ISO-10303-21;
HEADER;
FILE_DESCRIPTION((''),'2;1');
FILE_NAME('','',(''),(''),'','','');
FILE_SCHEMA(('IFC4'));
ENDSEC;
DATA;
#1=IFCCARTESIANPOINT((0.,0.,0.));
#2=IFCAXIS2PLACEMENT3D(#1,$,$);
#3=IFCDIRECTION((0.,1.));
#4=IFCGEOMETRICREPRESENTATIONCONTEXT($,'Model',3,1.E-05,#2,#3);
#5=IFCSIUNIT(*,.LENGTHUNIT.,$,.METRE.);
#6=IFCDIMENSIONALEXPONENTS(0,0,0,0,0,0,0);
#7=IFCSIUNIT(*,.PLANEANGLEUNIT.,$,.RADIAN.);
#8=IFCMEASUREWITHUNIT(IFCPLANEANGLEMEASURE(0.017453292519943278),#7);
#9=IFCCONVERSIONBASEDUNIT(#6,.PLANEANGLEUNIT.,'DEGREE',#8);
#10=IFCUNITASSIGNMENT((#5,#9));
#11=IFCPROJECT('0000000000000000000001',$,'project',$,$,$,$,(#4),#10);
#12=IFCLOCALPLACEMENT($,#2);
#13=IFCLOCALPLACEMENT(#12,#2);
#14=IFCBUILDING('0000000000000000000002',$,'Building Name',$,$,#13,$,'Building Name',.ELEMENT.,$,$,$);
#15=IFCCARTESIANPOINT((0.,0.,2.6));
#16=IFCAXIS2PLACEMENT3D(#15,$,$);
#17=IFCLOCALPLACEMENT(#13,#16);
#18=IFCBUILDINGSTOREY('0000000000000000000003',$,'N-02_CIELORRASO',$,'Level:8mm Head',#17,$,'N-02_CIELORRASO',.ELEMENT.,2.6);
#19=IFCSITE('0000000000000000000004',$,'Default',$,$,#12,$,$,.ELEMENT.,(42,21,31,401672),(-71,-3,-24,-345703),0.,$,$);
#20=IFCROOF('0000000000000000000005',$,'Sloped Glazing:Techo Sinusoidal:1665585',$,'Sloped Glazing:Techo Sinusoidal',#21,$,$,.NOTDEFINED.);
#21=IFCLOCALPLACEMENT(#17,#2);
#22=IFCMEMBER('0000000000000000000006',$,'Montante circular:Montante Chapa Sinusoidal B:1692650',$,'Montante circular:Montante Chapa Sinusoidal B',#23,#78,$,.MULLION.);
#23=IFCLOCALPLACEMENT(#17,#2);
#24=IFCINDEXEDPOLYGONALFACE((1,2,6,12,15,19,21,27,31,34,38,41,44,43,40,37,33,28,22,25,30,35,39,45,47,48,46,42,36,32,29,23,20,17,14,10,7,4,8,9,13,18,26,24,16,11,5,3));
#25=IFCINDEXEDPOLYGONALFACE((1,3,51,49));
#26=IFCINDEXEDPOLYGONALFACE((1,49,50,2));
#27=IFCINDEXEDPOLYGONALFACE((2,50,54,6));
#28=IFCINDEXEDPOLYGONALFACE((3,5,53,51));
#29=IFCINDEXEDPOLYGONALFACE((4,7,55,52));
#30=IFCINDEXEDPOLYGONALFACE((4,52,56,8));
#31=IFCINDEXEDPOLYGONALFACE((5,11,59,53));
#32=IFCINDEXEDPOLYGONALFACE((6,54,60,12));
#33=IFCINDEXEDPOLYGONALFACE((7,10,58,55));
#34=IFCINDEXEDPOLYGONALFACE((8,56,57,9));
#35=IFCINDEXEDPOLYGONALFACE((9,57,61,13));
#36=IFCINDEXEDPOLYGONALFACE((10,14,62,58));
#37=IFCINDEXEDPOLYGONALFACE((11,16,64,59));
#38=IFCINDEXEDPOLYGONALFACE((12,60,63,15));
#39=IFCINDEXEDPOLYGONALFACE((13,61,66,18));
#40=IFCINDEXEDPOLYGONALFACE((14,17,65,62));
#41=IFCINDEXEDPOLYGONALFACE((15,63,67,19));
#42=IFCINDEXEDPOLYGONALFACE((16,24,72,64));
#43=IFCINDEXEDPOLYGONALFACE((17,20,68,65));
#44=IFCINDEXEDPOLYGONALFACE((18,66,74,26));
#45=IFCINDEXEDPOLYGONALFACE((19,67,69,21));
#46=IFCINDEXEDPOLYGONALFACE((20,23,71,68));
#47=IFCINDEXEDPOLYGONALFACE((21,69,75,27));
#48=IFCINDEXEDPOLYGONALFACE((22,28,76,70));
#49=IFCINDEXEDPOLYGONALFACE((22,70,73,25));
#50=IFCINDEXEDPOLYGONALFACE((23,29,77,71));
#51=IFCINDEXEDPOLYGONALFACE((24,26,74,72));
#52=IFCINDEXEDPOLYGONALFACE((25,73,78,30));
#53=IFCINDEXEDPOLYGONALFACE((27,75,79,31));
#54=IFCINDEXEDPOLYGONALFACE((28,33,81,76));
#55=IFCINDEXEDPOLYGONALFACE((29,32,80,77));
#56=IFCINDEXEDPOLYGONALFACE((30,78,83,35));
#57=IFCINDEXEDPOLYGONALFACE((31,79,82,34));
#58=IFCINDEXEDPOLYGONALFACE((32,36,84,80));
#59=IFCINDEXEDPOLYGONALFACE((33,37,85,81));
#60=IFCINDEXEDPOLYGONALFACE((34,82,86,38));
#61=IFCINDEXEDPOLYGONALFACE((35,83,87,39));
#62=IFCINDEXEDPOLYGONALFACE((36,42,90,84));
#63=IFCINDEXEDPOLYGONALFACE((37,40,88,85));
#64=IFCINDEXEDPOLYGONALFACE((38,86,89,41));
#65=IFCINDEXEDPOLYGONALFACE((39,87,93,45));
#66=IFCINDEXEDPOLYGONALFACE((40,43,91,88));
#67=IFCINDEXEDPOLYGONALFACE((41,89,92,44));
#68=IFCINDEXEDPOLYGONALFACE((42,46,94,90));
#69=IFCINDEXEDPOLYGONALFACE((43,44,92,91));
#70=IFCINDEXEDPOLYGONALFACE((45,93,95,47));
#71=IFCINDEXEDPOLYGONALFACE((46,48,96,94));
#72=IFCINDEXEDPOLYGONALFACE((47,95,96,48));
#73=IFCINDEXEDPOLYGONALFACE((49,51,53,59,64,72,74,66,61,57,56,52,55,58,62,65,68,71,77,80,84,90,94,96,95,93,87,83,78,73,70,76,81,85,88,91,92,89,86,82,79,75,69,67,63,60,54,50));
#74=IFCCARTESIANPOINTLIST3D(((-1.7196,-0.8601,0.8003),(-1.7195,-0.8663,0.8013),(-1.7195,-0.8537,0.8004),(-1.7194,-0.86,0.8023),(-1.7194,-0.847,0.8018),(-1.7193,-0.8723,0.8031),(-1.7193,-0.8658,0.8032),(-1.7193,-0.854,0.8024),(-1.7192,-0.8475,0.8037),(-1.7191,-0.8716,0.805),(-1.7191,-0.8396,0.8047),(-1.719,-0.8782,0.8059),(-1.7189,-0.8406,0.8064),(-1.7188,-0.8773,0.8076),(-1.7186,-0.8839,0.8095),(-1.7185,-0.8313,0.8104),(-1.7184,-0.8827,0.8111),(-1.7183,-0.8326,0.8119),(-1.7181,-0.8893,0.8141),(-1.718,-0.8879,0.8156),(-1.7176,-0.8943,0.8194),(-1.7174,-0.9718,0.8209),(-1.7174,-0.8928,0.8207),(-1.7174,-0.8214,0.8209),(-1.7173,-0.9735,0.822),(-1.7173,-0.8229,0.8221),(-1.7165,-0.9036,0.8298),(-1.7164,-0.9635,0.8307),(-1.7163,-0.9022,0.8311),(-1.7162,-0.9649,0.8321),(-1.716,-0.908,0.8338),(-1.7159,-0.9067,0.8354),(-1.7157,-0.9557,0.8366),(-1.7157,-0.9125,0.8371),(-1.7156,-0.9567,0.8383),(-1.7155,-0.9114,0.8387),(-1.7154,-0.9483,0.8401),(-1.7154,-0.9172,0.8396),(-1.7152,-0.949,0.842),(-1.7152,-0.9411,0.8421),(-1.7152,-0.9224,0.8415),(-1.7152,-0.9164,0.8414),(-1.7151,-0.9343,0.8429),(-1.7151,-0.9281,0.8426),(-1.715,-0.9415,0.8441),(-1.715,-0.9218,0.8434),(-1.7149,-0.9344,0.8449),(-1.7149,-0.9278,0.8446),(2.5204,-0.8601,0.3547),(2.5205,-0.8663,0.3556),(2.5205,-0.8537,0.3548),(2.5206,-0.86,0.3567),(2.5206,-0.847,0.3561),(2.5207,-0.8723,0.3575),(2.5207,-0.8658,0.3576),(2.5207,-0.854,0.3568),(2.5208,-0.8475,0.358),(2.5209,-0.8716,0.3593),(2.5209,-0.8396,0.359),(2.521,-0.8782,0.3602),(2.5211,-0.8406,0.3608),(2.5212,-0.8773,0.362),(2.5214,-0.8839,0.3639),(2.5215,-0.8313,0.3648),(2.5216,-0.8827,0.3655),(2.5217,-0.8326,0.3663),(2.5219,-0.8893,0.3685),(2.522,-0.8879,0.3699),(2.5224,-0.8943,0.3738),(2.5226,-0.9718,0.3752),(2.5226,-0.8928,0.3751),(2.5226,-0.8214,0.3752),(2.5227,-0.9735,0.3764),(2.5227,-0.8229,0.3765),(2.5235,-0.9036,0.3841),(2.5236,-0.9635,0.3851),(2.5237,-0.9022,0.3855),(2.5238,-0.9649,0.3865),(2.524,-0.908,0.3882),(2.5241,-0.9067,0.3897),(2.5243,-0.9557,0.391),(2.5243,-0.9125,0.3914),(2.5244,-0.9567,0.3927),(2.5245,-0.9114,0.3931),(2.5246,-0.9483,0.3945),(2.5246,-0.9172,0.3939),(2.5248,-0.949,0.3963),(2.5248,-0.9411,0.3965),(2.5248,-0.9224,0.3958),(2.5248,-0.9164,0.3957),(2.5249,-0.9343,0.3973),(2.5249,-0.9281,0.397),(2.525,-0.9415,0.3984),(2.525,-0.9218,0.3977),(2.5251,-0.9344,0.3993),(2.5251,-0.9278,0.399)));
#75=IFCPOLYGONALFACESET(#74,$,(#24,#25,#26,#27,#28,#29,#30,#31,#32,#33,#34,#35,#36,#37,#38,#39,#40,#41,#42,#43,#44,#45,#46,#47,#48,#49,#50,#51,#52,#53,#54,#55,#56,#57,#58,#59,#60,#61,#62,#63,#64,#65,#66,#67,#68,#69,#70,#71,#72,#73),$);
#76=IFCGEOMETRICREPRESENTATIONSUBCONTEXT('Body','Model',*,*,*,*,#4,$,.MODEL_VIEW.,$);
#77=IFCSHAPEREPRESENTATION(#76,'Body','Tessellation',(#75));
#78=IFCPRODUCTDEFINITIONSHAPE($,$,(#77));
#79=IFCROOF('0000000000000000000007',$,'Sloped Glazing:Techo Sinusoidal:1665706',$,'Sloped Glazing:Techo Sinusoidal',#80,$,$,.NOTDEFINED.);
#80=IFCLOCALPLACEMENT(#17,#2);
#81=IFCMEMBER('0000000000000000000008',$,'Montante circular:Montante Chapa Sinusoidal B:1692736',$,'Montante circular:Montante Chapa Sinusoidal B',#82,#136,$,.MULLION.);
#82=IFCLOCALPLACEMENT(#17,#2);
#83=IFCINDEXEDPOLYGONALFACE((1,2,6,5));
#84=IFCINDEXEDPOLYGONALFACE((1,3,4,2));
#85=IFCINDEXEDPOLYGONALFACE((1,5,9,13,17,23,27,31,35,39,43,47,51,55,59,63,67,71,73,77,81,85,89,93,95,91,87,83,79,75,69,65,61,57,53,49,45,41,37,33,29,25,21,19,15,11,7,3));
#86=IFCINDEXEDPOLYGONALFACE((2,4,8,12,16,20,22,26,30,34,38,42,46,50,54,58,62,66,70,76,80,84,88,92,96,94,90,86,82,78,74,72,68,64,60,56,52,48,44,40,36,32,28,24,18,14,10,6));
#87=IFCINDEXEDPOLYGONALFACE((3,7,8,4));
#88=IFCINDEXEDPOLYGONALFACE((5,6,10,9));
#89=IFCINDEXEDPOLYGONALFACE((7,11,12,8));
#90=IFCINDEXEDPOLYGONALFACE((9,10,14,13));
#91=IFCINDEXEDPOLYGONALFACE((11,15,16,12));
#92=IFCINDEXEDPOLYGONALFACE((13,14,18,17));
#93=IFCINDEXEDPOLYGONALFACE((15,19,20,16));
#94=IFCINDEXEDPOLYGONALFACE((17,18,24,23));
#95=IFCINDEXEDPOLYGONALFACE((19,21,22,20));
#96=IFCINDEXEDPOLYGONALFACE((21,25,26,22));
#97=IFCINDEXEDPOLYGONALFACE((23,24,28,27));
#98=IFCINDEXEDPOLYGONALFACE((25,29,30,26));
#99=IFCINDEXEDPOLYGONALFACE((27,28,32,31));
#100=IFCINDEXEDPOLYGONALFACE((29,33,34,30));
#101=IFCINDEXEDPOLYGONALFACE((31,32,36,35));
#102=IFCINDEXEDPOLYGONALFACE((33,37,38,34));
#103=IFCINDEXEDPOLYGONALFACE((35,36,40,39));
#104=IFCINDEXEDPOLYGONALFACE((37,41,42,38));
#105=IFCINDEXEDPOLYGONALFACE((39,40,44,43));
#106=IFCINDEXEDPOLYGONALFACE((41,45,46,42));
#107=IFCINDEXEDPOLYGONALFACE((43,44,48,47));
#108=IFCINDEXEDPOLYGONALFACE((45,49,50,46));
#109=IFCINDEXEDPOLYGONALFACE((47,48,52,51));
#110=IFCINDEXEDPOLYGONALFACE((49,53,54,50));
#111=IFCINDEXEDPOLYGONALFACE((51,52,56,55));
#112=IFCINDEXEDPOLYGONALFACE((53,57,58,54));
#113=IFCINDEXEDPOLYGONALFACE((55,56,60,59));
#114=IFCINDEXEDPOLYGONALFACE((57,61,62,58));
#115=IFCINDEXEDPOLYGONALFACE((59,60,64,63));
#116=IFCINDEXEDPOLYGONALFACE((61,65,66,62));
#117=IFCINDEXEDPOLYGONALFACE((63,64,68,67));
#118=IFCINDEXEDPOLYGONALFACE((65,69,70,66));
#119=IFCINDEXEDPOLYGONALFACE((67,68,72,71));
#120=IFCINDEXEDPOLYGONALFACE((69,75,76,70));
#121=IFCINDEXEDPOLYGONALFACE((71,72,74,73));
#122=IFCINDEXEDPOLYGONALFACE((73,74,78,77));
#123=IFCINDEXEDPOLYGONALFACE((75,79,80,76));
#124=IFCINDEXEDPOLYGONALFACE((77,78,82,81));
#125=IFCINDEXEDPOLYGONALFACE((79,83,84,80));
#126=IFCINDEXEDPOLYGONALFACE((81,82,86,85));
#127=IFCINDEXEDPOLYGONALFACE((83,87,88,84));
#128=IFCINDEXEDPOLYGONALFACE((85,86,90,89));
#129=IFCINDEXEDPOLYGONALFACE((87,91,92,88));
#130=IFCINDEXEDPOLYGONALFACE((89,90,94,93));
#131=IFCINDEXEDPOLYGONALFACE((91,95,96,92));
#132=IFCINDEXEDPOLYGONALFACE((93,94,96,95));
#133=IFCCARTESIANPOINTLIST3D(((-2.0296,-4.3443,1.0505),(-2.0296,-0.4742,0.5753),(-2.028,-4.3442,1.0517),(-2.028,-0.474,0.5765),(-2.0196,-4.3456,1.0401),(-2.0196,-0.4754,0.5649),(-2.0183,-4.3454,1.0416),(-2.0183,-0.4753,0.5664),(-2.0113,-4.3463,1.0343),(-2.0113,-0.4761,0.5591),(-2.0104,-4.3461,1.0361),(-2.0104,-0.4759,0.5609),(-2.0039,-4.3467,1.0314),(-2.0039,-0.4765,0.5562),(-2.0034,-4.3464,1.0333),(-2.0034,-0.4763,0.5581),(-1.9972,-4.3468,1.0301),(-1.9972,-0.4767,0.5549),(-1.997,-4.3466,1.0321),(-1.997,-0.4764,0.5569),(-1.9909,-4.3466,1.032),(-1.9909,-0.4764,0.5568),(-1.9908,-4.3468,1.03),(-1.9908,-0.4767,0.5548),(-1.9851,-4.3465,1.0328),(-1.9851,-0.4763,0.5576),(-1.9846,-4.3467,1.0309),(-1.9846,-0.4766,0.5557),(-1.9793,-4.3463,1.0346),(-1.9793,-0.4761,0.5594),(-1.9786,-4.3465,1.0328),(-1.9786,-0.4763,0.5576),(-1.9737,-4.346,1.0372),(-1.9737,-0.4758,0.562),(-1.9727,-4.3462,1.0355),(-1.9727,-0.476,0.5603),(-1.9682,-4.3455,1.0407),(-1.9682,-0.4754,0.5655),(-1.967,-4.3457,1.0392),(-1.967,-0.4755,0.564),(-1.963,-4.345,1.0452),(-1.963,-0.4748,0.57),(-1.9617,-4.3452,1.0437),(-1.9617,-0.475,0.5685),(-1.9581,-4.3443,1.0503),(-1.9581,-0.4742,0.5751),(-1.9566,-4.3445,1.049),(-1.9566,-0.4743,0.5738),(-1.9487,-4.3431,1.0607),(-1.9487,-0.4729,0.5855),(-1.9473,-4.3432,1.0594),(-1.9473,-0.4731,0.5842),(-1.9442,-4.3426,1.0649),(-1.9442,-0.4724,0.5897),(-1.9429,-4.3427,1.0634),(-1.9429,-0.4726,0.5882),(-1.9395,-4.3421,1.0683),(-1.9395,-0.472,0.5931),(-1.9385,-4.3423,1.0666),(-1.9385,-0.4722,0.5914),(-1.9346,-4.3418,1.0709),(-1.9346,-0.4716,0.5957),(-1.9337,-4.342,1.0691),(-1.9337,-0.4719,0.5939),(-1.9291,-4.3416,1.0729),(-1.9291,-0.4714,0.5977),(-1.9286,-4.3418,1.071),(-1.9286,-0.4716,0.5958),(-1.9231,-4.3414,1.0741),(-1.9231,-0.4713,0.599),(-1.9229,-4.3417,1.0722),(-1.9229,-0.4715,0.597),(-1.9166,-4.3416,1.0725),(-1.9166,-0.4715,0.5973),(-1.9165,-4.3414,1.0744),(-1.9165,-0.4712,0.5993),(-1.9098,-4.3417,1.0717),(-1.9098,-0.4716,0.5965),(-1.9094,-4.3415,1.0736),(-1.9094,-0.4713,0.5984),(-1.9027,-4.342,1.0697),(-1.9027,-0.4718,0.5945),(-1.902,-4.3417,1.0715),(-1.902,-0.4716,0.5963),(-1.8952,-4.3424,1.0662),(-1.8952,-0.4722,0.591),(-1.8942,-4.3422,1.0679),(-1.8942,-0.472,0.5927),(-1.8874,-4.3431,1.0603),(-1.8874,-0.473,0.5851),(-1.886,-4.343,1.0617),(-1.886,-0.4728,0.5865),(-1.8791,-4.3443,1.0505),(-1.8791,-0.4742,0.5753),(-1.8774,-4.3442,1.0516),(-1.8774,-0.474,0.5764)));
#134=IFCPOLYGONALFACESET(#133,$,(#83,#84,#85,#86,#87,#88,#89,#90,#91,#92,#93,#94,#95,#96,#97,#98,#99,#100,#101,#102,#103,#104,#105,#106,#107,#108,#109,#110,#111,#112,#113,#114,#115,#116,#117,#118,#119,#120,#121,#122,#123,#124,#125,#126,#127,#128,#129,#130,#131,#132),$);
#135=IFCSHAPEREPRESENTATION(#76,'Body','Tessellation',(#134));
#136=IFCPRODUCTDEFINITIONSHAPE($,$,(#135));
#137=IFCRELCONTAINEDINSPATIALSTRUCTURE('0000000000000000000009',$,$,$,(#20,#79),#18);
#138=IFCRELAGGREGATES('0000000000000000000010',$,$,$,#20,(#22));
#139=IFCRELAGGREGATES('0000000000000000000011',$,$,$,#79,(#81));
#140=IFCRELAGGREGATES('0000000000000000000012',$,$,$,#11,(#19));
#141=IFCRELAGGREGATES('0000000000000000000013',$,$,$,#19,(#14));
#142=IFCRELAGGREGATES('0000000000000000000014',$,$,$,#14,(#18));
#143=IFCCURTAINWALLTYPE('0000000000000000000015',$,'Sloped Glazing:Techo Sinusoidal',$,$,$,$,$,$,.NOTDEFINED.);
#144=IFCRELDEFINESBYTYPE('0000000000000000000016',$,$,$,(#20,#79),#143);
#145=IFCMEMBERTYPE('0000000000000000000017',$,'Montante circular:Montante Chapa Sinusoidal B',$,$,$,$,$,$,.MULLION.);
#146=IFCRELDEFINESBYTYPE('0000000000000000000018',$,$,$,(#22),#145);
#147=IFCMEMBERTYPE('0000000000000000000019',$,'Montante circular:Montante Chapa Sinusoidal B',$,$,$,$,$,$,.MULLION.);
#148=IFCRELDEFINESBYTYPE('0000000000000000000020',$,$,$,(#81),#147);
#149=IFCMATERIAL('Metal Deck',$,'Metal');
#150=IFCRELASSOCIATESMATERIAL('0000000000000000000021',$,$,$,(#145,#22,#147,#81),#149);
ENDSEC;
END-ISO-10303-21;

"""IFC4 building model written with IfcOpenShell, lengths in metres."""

from ifc_helpers import new_model, entity, si_unit, converted_unit, direction, frame, origin, place, context, subcontext, project, spatial, indexed_curve, outline, extrude, source, transform, mapped, material, type_object, type_shapes, element, aggregate, save


model = new_model("IFC4")

# Units and contexts
model_context = context("Model", 3, precision=1e-05, world=origin(), true_north=direction((0.0, 1.0)))
body_context = subcontext(model_context, "Body", "Model", "MODEL_VIEW")
ifc_project = project(units=[si_unit("LENGTHUNIT", "METRE"), converted_unit("PLANEANGLEUNIT", "DEGREE", entity("IfcPlaneAngleMeasure", 0.017453292519943278), si_unit("PLANEANGLEUNIT", "RADIAN"), dimensions=[0, 0, 0, 0, 0, 0, 0])], contexts=[model_context])

# Site, building, storey
site_placement = place(None, origin())
site = spatial("IfcSite", under=ifc_project, at=site_placement, Name="Default", CompositionType="ELEMENT", RefLatitude=(42, 21, 31, 401672), RefLongitude=(-71, -3, -24, -345703), RefElevation=0.0)
building_placement = place(site_placement, origin())
building = spatial("IfcBuilding", under=site, at=building_placement, Name="Building Name", LongName="Building Name", CompositionType="ELEMENT")
storey_placement = place(building_placement, frame((0.0, 0.0, 2.6)))
storey = spatial("IfcBuildingStorey", under=building, at=storey_placement, Name="N-02_CIELORRASO", ObjectType="Level:8mm Head", LongName="N-02_CIELORRASO", CompositionType="ELEMENT", Elevation=2.6)

# Roofs, members
curtain_wall_type = type_object("IfcCurtainWallType", Name="Sloped Glazing:Techo Sinusoidal", PredefinedType="NOTDEFINED")
roof_1_placement = place(storey_placement, frame((0.0, 0.0, -2.6)))
roof_1 = element("IfcRoof", 1, at=roof_1_placement, inside=storey, type_object=curtain_wall_type, Name="Sloped Glazing:Techo Sinusoidal:1665585", ObjectType="Sloped Glazing:Techo Sinusoidal", PredefinedType="NOTDEFINED")
ifc_material = material(Name="Metal Deck", Category="Metal")
member_type_1 = type_object("IfcMemberType", Name="Montante circular:Montante Chapa Sinusoidal B", PredefinedType="MULLION", material=ifc_material)
shared_shape_1 = source(origin(), body_context, "Body", "SweptSolid", [
    extrude(outline(indexed_curve([(0.0595, -0.0443), (0.0615, -0.0443), (0.0603, -0.031), (0.0572, -0.0213), (0.053, -0.0138), (0.0481, -0.0078), (0.0427, -0.003), (0.0372, 0.0005), (0.0315, 0.0029), (0.0259, 0.0044), (0.0203, 0.0051), (0.0146, 0.005), (0.0084, 0.0041), (-0.0053, 0.0009), (-0.0123, -0.0005), (-0.0191, -0.0012), (-0.0256, -0.001), (-0.0317, 0.0001), (-0.0375, 0.0019), (-0.0428, 0.0046), (-0.0477, 0.0081), (-0.0522, 0.0128), (-0.0563, 0.0191), (-0.0597, 0.0282), (-0.0617, 0.0421), (-0.0637, 0.042), (-0.0616, 0.0277), (-0.0581, 0.0182), (-0.0537, 0.0116), (-0.049, 0.0066), (-0.0438, 0.0028), (-0.0382, 0.0001), (-0.0322, -0.0019), (-0.0258, -0.003), (-0.019, -0.0032), (-0.012, -0.0025), (-0.0048, -0.0011), (0.0088, 0.0021), (0.0147, 0.003), (0.0202, 0.0031), (0.0255, 0.0024), (0.0309, 0.001), (0.0362, -0.0013), (0.0415, -0.0046), (0.0466, -0.0092), (0.0513, -0.0149), (0.0554, -0.0221), (0.0584, -0.0314), (0.0595, -0.0443)], self_intersect=False)), frame((-0.007, 0.0228, -4.2634), z_axis=(0.0, 0.0, 1.0), x_axis=(-0.819152, -0.573576, 0.0)), (0.0, 0.0, 1.0), 4.2634),
])
type_shapes(member_type_1, [shared_shape_1])
member_1_placement = place(roof_1_placement, frame((-1.7148, -0.8906, 3.4456), z_axis=(-0.994522, 0.0, 0.104528), x_axis=(0.0, 1.0, 0.0)))
member_1 = element("IfcMember", 2, at=member_1_placement, type_object=member_type_1, material=ifc_material, Name="Montante circular:Montante Chapa Sinusoidal B:1692650", ObjectType="Montante circular:Montante Chapa Sinusoidal B", PredefinedType="MULLION", context=body_context, shape_type="MappedRepresentation", body=[
    mapped(shared_shape_1, transform((0.0, 0.0, 0.0), scale=1.0)),
])
aggregate(roof_1, [member_1])
roof_2_placement = place(storey_placement, frame((0.0, 0.0, -2.6)))
roof_2 = element("IfcRoof", 3, at=roof_2_placement, inside=storey, type_object=curtain_wall_type, Name="Sloped Glazing:Techo Sinusoidal:1665706", ObjectType="Sloped Glazing:Techo Sinusoidal", PredefinedType="NOTDEFINED")
member_type_2 = type_object("IfcMemberType", Name="Montante circular:Montante Chapa Sinusoidal B", PredefinedType="MULLION", material=ifc_material)
shared_shape_2 = source(origin(), body_context, "Body", "SweptSolid", [
    extrude(outline(indexed_curve([(0.0595, -0.0443), (0.0615, -0.0443), (0.0603, -0.031), (0.0572, -0.0213), (0.053, -0.0138), (0.0481, -0.0078), (0.0427, -0.003), (0.0372, 0.0005), (0.0315, 0.0029), (0.0259, 0.0044), (0.0203, 0.0051), (0.0146, 0.005), (0.0084, 0.0041), (-0.0053, 0.0009), (-0.0123, -0.0005), (-0.0191, -0.0012), (-0.0256, -0.001), (-0.0317, 0.0001), (-0.0375, 0.0019), (-0.0428, 0.0046), (-0.0477, 0.0081), (-0.0522, 0.0128), (-0.0563, 0.0191), (-0.0597, 0.0282), (-0.0617, 0.0421), (-0.0637, 0.042), (-0.0616, 0.0277), (-0.0581, 0.0182), (-0.0537, 0.0116), (-0.049, 0.0066), (-0.0438, 0.0028), (-0.0382, 0.0001), (-0.0322, -0.0019), (-0.0258, -0.003), (-0.019, -0.0032), (-0.012, -0.0025), (-0.0048, -0.0011), (0.0088, 0.0021), (0.0147, 0.003), (0.0202, 0.0031), (0.0255, 0.0024), (0.0309, 0.001), (0.0362, -0.0013), (0.0415, -0.0046), (0.0466, -0.0092), (0.0513, -0.0149), (0.0554, -0.0221), (0.0584, -0.0314), (0.0595, -0.0443)], self_intersect=False)), frame((-0.007, 0.0228, -3.8992), z_axis=(0.0, 0.0, 1.0), x_axis=(-0.819152, -0.573576, 0.0)), (0.0, 0.0, 1.0), 3.8992),
])
type_shapes(member_type_2, [shared_shape_2])
member_2_placement = place(roof_2_placement, frame((-1.9603, -4.3413, 3.6752), z_axis=(0.0, -0.992546, 0.121869), x_axis=(-1.0, 0.0, 0.0)))
member_2 = element("IfcMember", 4, at=member_2_placement, type_object=member_type_2, material=ifc_material, Name="Montante circular:Montante Chapa Sinusoidal B:1692736", ObjectType="Montante circular:Montante Chapa Sinusoidal B", PredefinedType="MULLION", context=body_context, shape_type="MappedRepresentation", body=[
    mapped(shared_shape_2, transform((0.0, 0.0, 0.0), scale=1.0)),
])
aggregate(roof_2, [member_2])

save(model, "model.ifc")
